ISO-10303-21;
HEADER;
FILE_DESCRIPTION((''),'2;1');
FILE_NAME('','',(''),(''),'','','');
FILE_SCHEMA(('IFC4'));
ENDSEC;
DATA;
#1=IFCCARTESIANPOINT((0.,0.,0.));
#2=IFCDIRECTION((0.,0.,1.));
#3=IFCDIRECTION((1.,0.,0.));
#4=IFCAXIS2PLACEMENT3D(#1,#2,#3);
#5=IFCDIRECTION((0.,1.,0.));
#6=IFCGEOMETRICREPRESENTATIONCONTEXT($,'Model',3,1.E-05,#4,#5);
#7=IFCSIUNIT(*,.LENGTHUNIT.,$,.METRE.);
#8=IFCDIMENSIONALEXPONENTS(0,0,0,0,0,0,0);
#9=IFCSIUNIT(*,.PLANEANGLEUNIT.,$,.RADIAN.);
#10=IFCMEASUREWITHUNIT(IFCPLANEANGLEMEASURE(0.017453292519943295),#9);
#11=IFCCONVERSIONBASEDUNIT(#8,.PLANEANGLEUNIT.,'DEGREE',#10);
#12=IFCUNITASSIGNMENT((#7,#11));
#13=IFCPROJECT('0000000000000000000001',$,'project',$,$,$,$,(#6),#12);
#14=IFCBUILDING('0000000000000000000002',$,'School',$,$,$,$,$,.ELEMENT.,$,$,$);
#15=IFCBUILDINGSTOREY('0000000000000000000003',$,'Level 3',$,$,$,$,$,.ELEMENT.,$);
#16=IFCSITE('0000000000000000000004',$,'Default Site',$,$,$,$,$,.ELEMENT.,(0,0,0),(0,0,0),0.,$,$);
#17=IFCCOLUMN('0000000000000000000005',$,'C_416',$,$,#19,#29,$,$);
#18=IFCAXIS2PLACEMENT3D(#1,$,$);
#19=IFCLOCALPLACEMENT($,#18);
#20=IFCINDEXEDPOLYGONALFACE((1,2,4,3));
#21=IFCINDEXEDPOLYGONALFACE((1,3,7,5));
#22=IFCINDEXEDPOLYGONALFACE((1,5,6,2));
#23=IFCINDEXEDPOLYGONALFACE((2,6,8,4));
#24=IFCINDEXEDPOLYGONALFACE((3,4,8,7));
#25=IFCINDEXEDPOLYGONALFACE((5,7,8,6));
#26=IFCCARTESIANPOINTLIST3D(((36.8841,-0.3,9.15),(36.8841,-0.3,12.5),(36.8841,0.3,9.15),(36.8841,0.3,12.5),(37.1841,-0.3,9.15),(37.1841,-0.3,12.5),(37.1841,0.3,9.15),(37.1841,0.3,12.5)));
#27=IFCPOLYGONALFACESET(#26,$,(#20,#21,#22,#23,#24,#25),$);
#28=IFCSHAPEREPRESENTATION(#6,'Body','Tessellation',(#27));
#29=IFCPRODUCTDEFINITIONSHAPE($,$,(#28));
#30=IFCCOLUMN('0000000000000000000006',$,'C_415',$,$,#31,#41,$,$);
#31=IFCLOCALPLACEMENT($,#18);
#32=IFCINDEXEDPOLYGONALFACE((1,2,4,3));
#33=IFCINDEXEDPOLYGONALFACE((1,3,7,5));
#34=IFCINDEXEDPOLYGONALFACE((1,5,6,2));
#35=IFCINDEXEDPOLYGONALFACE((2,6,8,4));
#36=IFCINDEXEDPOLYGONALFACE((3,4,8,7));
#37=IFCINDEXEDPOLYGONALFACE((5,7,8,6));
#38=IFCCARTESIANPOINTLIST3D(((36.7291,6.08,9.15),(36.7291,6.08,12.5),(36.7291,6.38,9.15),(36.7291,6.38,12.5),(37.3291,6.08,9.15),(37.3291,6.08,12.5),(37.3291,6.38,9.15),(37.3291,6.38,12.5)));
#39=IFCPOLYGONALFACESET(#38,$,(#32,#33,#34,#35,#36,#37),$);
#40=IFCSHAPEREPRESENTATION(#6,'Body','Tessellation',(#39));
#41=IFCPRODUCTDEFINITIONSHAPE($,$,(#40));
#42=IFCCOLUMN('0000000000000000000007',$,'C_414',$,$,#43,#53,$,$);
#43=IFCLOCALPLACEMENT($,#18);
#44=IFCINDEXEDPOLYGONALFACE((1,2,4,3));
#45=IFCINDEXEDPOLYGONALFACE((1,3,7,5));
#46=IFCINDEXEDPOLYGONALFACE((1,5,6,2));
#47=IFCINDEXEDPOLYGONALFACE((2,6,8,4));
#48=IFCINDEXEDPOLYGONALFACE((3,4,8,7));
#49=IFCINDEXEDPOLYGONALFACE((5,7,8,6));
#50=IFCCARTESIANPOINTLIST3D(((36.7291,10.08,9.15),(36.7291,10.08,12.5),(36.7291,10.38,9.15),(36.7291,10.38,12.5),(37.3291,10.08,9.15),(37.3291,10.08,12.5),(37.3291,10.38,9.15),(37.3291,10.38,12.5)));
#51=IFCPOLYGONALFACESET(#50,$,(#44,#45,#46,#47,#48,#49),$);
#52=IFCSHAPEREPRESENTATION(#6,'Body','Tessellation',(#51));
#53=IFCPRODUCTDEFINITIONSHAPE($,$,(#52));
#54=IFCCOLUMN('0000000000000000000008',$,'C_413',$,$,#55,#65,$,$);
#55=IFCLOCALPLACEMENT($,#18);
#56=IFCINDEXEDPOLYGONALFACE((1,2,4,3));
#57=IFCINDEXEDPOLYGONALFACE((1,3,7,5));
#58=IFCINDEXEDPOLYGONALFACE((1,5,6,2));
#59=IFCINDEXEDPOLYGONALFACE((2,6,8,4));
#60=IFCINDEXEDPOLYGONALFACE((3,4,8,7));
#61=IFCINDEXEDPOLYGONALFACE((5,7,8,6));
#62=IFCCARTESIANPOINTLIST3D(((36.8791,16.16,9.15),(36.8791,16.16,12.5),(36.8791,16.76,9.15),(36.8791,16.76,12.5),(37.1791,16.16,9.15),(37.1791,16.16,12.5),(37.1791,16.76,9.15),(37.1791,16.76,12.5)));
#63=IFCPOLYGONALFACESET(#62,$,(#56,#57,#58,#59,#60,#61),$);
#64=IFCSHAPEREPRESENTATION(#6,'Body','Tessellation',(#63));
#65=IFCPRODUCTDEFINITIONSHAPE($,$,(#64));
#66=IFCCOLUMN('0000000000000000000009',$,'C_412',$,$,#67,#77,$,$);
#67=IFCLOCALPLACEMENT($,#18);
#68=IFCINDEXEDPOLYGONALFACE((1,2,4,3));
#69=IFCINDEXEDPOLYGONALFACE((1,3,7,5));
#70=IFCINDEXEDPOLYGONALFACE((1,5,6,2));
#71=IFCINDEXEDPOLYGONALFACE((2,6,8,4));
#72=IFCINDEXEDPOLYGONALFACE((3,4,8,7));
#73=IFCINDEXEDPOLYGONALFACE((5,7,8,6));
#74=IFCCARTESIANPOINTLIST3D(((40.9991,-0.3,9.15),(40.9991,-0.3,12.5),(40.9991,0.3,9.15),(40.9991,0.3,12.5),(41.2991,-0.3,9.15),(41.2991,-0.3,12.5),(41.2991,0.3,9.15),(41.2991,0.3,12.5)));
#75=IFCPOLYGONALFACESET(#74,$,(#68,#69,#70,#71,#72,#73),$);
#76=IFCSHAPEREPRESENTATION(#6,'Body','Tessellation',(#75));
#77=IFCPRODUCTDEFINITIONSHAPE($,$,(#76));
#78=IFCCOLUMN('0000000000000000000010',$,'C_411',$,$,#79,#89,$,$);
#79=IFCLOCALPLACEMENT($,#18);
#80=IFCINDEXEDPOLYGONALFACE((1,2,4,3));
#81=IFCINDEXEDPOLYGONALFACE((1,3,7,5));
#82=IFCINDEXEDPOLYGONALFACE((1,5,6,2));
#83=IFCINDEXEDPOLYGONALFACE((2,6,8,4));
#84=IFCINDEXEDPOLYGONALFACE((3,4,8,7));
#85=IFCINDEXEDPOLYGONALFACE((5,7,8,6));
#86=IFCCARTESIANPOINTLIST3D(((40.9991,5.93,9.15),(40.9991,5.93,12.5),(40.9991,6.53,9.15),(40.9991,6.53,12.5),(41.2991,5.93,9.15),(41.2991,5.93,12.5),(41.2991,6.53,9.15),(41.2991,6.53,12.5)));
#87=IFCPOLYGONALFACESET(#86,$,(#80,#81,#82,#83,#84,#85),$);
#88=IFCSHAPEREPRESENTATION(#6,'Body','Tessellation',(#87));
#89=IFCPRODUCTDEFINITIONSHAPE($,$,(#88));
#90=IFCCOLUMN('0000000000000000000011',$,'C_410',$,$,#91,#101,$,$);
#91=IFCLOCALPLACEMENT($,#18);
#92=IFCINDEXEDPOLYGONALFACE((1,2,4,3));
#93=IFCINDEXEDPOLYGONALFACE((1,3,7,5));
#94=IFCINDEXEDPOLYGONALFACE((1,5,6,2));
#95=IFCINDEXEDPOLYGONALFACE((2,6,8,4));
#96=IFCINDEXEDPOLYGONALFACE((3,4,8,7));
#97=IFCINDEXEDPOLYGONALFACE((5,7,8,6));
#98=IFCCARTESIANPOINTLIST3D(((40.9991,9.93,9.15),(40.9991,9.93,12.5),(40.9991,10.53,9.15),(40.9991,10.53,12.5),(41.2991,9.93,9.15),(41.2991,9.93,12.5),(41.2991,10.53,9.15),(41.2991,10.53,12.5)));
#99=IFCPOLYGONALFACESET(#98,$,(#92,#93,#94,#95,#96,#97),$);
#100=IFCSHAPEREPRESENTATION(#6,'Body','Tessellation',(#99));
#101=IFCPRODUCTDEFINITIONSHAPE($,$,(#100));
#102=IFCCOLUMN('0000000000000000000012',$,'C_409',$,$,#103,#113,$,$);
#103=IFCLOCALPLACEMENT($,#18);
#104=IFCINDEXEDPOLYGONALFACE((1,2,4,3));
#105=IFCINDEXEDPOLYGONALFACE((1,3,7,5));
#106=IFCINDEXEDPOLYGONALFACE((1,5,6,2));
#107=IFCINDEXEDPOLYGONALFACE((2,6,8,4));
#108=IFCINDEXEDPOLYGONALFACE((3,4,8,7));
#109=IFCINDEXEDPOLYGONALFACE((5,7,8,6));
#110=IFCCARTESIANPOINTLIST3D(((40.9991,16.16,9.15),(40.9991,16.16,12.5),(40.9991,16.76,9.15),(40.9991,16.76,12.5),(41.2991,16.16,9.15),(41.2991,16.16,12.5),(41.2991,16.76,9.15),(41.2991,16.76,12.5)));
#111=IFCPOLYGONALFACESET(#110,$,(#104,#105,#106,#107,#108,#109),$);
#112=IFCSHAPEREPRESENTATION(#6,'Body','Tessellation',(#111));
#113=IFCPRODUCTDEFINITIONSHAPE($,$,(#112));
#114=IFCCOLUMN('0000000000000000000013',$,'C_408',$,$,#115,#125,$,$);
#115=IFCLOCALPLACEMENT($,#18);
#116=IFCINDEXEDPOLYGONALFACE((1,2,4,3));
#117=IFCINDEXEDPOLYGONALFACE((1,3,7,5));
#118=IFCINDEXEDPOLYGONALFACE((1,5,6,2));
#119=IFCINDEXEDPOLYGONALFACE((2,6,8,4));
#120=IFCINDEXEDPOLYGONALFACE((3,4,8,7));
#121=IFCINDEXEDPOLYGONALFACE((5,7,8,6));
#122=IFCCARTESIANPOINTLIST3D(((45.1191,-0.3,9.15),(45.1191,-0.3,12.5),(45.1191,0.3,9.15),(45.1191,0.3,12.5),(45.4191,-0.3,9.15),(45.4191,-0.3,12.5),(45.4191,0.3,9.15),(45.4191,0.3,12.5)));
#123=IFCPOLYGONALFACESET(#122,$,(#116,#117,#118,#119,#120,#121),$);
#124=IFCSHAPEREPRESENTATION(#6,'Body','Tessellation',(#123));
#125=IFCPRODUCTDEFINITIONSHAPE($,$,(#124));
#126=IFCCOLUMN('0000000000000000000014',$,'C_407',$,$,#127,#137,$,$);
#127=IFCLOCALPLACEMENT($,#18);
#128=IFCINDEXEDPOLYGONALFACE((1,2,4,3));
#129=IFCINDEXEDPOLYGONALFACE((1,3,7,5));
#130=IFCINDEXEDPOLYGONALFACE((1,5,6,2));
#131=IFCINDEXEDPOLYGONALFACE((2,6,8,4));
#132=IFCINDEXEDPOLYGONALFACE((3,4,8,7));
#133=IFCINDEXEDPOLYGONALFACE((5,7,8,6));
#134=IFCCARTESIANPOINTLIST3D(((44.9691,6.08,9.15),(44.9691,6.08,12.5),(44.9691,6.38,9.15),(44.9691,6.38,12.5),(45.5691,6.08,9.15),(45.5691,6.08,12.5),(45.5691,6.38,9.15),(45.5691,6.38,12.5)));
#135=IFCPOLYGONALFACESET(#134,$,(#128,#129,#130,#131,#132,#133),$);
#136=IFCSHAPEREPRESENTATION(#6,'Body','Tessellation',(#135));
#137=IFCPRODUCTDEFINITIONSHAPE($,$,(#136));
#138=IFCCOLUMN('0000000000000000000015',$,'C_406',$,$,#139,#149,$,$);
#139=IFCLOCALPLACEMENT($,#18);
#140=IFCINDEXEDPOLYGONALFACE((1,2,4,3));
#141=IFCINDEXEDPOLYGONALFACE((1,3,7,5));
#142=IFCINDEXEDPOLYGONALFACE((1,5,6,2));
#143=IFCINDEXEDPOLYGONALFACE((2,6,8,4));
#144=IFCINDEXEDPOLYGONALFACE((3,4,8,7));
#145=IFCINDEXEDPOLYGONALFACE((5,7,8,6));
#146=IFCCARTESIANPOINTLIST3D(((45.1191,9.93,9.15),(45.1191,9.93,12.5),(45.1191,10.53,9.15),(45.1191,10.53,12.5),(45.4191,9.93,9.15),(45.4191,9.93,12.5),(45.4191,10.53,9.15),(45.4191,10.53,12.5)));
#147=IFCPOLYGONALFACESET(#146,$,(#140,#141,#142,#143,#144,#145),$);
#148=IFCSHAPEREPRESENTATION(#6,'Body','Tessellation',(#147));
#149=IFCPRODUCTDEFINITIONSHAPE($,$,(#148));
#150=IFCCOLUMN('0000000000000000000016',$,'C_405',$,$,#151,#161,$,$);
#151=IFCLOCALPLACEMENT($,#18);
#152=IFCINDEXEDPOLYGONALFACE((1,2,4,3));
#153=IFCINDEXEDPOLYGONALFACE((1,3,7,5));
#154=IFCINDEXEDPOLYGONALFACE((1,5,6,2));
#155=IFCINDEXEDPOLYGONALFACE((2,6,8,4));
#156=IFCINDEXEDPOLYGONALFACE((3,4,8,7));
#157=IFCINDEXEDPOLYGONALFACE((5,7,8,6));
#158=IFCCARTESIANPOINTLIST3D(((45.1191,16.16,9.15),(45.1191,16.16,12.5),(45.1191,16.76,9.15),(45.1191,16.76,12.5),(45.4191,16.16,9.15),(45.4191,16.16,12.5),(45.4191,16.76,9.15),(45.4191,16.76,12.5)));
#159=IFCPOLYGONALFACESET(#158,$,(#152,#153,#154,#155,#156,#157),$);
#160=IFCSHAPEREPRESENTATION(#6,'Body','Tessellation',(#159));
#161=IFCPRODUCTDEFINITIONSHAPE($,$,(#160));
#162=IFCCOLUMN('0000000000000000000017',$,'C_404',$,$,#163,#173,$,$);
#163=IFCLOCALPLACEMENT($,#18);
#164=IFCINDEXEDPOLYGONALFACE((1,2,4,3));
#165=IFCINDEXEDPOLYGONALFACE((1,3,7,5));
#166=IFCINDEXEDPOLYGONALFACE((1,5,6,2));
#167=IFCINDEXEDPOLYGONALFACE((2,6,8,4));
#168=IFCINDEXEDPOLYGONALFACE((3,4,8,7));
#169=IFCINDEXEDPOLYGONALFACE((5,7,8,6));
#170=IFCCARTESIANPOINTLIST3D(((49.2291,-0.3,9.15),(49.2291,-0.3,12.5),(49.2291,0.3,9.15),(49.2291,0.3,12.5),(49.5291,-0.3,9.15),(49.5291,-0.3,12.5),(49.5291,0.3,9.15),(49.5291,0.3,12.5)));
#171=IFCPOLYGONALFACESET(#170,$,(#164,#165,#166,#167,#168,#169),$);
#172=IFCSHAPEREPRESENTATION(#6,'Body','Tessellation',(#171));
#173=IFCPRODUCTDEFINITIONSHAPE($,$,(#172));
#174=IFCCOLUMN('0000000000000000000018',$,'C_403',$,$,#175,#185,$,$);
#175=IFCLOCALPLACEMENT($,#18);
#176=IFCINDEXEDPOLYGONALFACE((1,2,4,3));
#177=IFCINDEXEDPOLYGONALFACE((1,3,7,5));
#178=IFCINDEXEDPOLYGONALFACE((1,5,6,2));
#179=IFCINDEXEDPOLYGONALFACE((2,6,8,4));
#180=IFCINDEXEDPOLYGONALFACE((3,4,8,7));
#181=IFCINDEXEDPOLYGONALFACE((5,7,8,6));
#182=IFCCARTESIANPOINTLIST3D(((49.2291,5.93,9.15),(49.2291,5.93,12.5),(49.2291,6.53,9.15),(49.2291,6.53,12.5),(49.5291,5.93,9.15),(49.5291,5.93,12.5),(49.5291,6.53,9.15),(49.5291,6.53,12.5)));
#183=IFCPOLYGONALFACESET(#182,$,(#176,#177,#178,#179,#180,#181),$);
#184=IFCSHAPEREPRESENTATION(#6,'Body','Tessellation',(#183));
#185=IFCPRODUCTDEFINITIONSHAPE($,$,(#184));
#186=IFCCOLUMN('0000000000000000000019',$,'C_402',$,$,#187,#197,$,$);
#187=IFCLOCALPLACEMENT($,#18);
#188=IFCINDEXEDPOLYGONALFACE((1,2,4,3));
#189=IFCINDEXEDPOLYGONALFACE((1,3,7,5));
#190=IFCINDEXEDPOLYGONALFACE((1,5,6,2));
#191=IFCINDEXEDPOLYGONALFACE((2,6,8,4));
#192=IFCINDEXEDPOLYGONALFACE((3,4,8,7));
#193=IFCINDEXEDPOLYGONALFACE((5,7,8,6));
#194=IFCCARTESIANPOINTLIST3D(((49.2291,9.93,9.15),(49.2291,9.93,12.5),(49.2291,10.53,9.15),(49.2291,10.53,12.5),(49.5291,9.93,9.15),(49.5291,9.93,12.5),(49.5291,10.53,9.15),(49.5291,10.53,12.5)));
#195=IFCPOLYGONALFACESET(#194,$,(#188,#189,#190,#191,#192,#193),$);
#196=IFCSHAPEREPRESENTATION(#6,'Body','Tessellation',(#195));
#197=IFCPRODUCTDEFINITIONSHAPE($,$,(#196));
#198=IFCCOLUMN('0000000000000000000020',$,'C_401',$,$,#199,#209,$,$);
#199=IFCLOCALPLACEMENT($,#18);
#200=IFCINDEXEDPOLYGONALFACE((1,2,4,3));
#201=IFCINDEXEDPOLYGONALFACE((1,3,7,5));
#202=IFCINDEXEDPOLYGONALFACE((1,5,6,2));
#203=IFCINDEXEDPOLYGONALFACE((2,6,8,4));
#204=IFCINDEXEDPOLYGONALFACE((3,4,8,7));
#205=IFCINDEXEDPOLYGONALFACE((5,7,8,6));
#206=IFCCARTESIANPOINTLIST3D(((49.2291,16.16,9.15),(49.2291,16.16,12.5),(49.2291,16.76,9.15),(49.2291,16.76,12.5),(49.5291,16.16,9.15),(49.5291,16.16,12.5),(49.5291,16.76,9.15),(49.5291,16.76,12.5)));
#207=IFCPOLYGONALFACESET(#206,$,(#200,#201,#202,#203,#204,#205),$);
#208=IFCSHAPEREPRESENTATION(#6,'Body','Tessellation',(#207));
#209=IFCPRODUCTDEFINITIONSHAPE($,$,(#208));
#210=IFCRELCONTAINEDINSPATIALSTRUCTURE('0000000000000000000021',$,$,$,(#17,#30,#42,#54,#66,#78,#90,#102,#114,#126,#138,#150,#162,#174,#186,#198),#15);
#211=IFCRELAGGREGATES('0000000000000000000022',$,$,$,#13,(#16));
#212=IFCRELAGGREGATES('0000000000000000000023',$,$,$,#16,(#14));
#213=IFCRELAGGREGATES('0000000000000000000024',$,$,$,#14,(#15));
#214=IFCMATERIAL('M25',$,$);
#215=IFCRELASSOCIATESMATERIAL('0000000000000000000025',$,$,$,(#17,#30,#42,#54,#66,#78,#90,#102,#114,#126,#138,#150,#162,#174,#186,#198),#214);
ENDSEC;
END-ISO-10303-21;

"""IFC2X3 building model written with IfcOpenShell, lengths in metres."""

from ifc_helpers import new_model, entity, si_unit, converted_unit, direction, frame, frame_2d, origin_with_axes, place, context, project, spatial, rectangle, extrude, material, element, save


model = new_model("IFC2X3")

# Units and contexts
model_context = context("Model", 3, precision=1e-05, world=origin_with_axes(), true_north=direction((0.0, 1.0, 0.0)))
ifc_project = project(units=[si_unit("LENGTHUNIT", "METRE"), converted_unit("PLANEANGLEUNIT", "DEGREE", entity("IfcPlaneAngleMeasure", 0.017453292519943295), si_unit("PLANEANGLEUNIT", "RADIAN"), dimensions=[0, 0, 0, 0, 0, 0, 0])], contexts=[model_context])

# Site, building, storey
site = spatial("IfcSite", under=ifc_project, Name="Default Site", CompositionType="ELEMENT", RefLatitude=(0, 0, 0), RefLongitude=(0, 0, 0), RefElevation=0.0)
building = spatial("IfcBuilding", under=site, Name="School", CompositionType="ELEMENT")
storey = spatial("IfcBuildingStorey", under=building, Name="Level 3", CompositionType="ELEMENT")

# Columns
ifc_material = material(Name="M25")
placement = place(None, origin_with_axes())
element("IfcColumn", 1, at=placement, inside=storey, material=ifc_material, Name="C_416", context=model_context, shape_type="SweptSolid", body=[
    extrude(rectangle(XDim=0.3, YDim=0.6, at=frame_2d((0.0, 0.0), x_axis=(1.0, 0.0, 0.0))), frame((37.0341, 0.0, 9.15), z_axis=(0.0, 0.0, 1.0), x_axis=(1.0, 0.0, 0.0)), (0.0, 0.0, 1.0), 3.35),
])
element("IfcColumn", 2, at=placement, inside=storey, material=ifc_material, Name="C_415", context=model_context, shape_type="SweptSolid", body=[
    extrude(rectangle(XDim=0.6, YDim=0.3, at=frame_2d((0.0, 0.0), x_axis=(1.0, 0.0, 0.0))), frame((37.0291, 6.23, 9.15), z_axis=(0.0, 0.0, 1.0), x_axis=(1.0, 0.0, 0.0)), (0.0, 0.0, 1.0), 3.35),
])
element("IfcColumn", 3, at=placement, inside=storey, material=ifc_material, Name="C_414", context=model_context, shape_type="SweptSolid", body=[
    extrude(rectangle(XDim=0.6, YDim=0.3, at=frame_2d((0.0, 0.0), x_axis=(1.0, 0.0, 0.0))), frame((37.0291, 10.23, 9.15), z_axis=(0.0, 0.0, 1.0), x_axis=(1.0, 0.0, 0.0)), (0.0, 0.0, 1.0), 3.35),
])
element("IfcColumn", 4, at=placement, inside=storey, material=ifc_material, Name="C_413", context=model_context, shape_type="SweptSolid", body=[
    extrude(rectangle(XDim=0.3, YDim=0.6, at=frame_2d((0.0, 0.0), x_axis=(1.0, 0.0, 0.0))), frame((37.0291, 16.46, 9.15), z_axis=(0.0, 0.0, 1.0), x_axis=(1.0, 0.0, 0.0)), (0.0, 0.0, 1.0), 3.35),
])
element("IfcColumn", 5, at=placement, inside=storey, material=ifc_material, Name="C_412", context=model_context, shape_type="SweptSolid", body=[
    extrude(rectangle(XDim=0.3, YDim=0.6, at=frame_2d((0.0, 0.0), x_axis=(1.0, 0.0, 0.0))), frame((41.1491, 0.0, 9.15), z_axis=(0.0, 0.0, 1.0), x_axis=(1.0, 0.0, 0.0)), (0.0, 0.0, 1.0), 3.35),
])
element("IfcColumn", 6, at=placement, inside=storey, material=ifc_material, Name="C_411", context=model_context, shape_type="SweptSolid", body=[
    extrude(rectangle(XDim=0.3, YDim=0.6, at=frame_2d((0.0, 0.0), x_axis=(1.0, 0.0, 0.0))), frame((41.1491, 6.23, 9.15), z_axis=(0.0, 0.0, 1.0), x_axis=(1.0, 0.0, 0.0)), (0.0, 0.0, 1.0), 3.35),
])
element("IfcColumn", 7, at=placement, inside=storey, material=ifc_material, Name="C_410", context=model_context, shape_type="SweptSolid", body=[
    extrude(rectangle(XDim=0.3, YDim=0.6, at=frame_2d((0.0, 0.0), x_axis=(1.0, 0.0, 0.0))), frame((41.1491, 10.23, 9.15), z_axis=(0.0, 0.0, 1.0), x_axis=(1.0, 0.0, 0.0)), (0.0, 0.0, 1.0), 3.35),
])
element("IfcColumn", 8, at=placement, inside=storey, material=ifc_material, Name="C_409", context=model_context, shape_type="SweptSolid", body=[
    extrude(rectangle(XDim=0.3, YDim=0.6, at=frame_2d((0.0, 0.0), x_axis=(1.0, 0.0, 0.0))), frame((41.1491, 16.46, 9.15), z_axis=(0.0, 0.0, 1.0), x_axis=(1.0, 0.0, 0.0)), (0.0, 0.0, 1.0), 3.35),
])
element("IfcColumn", 9, at=placement, inside=storey, material=ifc_material, Name="C_408", context=model_context, shape_type="SweptSolid", body=[
    extrude(rectangle(XDim=0.3, YDim=0.6, at=frame_2d((0.0, 0.0), x_axis=(1.0, 0.0, 0.0))), frame((45.2691, 0.0, 9.15), z_axis=(0.0, 0.0, 1.0), x_axis=(1.0, 0.0, 0.0)), (0.0, 0.0, 1.0), 3.35),
])
element("IfcColumn", 10, at=placement, inside=storey, material=ifc_material, Name="C_407", context=model_context, shape_type="SweptSolid", body=[
    extrude(rectangle(XDim=0.6, YDim=0.3, at=frame_2d((0.0, 0.0), x_axis=(1.0, 0.0, 0.0))), frame((45.2691, 6.23, 9.15), z_axis=(0.0, 0.0, 1.0), x_axis=(1.0, 0.0, 0.0)), (0.0, 0.0, 1.0), 3.35),
])
element("IfcColumn", 11, at=placement, inside=storey, material=ifc_material, Name="C_406", context=model_context, shape_type="SweptSolid", body=[
    extrude(rectangle(XDim=0.3, YDim=0.6, at=frame_2d((0.0, 0.0), x_axis=(1.0, 0.0, 0.0))), frame((45.2691, 10.23, 9.15), z_axis=(0.0, 0.0, 1.0), x_axis=(1.0, 0.0, 0.0)), (0.0, 0.0, 1.0), 3.35),
])
element("IfcColumn", 12, at=placement, inside=storey, material=ifc_material, Name="C_405", context=model_context, shape_type="SweptSolid", body=[
    extrude(rectangle(XDim=0.3, YDim=0.6, at=frame_2d((0.0, 0.0), x_axis=(1.0, 0.0, 0.0))), frame((45.2691, 16.46, 9.15), z_axis=(0.0, 0.0, 1.0), x_axis=(1.0, 0.0, 0.0)), (0.0, 0.0, 1.0), 3.35),
])
element("IfcColumn", 13, at=placement, inside=storey, material=ifc_material, Name="C_404", context=model_context, shape_type="SweptSolid", body=[
    extrude(rectangle(XDim=0.3, YDim=0.6, at=frame_2d((0.0, 0.0), x_axis=(1.0, 0.0, 0.0))), frame((49.3791, 0.0, 9.15), z_axis=(0.0, 0.0, 1.0), x_axis=(1.0, 0.0, 0.0)), (0.0, 0.0, 1.0), 3.35),
])
element("IfcColumn", 14, at=placement, inside=storey, material=ifc_material, Name="C_403", context=model_context, shape_type="SweptSolid", body=[
    extrude(rectangle(XDim=0.3, YDim=0.6, at=frame_2d((0.0, 0.0), x_axis=(1.0, 0.0, 0.0))), frame((49.3791, 6.23, 9.15), z_axis=(0.0, 0.0, 1.0), x_axis=(1.0, 0.0, 0.0)), (0.0, 0.0, 1.0), 3.35),
])
element("IfcColumn", 15, at=placement, inside=storey, material=ifc_material, Name="C_402", context=model_context, shape_type="SweptSolid", body=[
    extrude(rectangle(XDim=0.3, YDim=0.6, at=frame_2d((0.0, 0.0), x_axis=(1.0, 0.0, 0.0))), frame((49.3791, 10.23, 9.15), z_axis=(0.0, 0.0, 1.0), x_axis=(1.0, 0.0, 0.0)), (0.0, 0.0, 1.0), 3.35),
])
element("IfcColumn", 16, at=placement, inside=storey, material=ifc_material, Name="C_401", context=model_context, shape_type="SweptSolid", body=[
    extrude(rectangle(XDim=0.3, YDim=0.6, at=frame_2d((0.0, 0.0), x_axis=(1.0, 0.0, 0.0))), frame((49.3791, 16.46, 9.15), z_axis=(0.0, 0.0, 1.0), x_axis=(1.0, 0.0, 0.0)), (0.0, 0.0, 1.0), 3.35),
])

save(model, "model.ifc")
